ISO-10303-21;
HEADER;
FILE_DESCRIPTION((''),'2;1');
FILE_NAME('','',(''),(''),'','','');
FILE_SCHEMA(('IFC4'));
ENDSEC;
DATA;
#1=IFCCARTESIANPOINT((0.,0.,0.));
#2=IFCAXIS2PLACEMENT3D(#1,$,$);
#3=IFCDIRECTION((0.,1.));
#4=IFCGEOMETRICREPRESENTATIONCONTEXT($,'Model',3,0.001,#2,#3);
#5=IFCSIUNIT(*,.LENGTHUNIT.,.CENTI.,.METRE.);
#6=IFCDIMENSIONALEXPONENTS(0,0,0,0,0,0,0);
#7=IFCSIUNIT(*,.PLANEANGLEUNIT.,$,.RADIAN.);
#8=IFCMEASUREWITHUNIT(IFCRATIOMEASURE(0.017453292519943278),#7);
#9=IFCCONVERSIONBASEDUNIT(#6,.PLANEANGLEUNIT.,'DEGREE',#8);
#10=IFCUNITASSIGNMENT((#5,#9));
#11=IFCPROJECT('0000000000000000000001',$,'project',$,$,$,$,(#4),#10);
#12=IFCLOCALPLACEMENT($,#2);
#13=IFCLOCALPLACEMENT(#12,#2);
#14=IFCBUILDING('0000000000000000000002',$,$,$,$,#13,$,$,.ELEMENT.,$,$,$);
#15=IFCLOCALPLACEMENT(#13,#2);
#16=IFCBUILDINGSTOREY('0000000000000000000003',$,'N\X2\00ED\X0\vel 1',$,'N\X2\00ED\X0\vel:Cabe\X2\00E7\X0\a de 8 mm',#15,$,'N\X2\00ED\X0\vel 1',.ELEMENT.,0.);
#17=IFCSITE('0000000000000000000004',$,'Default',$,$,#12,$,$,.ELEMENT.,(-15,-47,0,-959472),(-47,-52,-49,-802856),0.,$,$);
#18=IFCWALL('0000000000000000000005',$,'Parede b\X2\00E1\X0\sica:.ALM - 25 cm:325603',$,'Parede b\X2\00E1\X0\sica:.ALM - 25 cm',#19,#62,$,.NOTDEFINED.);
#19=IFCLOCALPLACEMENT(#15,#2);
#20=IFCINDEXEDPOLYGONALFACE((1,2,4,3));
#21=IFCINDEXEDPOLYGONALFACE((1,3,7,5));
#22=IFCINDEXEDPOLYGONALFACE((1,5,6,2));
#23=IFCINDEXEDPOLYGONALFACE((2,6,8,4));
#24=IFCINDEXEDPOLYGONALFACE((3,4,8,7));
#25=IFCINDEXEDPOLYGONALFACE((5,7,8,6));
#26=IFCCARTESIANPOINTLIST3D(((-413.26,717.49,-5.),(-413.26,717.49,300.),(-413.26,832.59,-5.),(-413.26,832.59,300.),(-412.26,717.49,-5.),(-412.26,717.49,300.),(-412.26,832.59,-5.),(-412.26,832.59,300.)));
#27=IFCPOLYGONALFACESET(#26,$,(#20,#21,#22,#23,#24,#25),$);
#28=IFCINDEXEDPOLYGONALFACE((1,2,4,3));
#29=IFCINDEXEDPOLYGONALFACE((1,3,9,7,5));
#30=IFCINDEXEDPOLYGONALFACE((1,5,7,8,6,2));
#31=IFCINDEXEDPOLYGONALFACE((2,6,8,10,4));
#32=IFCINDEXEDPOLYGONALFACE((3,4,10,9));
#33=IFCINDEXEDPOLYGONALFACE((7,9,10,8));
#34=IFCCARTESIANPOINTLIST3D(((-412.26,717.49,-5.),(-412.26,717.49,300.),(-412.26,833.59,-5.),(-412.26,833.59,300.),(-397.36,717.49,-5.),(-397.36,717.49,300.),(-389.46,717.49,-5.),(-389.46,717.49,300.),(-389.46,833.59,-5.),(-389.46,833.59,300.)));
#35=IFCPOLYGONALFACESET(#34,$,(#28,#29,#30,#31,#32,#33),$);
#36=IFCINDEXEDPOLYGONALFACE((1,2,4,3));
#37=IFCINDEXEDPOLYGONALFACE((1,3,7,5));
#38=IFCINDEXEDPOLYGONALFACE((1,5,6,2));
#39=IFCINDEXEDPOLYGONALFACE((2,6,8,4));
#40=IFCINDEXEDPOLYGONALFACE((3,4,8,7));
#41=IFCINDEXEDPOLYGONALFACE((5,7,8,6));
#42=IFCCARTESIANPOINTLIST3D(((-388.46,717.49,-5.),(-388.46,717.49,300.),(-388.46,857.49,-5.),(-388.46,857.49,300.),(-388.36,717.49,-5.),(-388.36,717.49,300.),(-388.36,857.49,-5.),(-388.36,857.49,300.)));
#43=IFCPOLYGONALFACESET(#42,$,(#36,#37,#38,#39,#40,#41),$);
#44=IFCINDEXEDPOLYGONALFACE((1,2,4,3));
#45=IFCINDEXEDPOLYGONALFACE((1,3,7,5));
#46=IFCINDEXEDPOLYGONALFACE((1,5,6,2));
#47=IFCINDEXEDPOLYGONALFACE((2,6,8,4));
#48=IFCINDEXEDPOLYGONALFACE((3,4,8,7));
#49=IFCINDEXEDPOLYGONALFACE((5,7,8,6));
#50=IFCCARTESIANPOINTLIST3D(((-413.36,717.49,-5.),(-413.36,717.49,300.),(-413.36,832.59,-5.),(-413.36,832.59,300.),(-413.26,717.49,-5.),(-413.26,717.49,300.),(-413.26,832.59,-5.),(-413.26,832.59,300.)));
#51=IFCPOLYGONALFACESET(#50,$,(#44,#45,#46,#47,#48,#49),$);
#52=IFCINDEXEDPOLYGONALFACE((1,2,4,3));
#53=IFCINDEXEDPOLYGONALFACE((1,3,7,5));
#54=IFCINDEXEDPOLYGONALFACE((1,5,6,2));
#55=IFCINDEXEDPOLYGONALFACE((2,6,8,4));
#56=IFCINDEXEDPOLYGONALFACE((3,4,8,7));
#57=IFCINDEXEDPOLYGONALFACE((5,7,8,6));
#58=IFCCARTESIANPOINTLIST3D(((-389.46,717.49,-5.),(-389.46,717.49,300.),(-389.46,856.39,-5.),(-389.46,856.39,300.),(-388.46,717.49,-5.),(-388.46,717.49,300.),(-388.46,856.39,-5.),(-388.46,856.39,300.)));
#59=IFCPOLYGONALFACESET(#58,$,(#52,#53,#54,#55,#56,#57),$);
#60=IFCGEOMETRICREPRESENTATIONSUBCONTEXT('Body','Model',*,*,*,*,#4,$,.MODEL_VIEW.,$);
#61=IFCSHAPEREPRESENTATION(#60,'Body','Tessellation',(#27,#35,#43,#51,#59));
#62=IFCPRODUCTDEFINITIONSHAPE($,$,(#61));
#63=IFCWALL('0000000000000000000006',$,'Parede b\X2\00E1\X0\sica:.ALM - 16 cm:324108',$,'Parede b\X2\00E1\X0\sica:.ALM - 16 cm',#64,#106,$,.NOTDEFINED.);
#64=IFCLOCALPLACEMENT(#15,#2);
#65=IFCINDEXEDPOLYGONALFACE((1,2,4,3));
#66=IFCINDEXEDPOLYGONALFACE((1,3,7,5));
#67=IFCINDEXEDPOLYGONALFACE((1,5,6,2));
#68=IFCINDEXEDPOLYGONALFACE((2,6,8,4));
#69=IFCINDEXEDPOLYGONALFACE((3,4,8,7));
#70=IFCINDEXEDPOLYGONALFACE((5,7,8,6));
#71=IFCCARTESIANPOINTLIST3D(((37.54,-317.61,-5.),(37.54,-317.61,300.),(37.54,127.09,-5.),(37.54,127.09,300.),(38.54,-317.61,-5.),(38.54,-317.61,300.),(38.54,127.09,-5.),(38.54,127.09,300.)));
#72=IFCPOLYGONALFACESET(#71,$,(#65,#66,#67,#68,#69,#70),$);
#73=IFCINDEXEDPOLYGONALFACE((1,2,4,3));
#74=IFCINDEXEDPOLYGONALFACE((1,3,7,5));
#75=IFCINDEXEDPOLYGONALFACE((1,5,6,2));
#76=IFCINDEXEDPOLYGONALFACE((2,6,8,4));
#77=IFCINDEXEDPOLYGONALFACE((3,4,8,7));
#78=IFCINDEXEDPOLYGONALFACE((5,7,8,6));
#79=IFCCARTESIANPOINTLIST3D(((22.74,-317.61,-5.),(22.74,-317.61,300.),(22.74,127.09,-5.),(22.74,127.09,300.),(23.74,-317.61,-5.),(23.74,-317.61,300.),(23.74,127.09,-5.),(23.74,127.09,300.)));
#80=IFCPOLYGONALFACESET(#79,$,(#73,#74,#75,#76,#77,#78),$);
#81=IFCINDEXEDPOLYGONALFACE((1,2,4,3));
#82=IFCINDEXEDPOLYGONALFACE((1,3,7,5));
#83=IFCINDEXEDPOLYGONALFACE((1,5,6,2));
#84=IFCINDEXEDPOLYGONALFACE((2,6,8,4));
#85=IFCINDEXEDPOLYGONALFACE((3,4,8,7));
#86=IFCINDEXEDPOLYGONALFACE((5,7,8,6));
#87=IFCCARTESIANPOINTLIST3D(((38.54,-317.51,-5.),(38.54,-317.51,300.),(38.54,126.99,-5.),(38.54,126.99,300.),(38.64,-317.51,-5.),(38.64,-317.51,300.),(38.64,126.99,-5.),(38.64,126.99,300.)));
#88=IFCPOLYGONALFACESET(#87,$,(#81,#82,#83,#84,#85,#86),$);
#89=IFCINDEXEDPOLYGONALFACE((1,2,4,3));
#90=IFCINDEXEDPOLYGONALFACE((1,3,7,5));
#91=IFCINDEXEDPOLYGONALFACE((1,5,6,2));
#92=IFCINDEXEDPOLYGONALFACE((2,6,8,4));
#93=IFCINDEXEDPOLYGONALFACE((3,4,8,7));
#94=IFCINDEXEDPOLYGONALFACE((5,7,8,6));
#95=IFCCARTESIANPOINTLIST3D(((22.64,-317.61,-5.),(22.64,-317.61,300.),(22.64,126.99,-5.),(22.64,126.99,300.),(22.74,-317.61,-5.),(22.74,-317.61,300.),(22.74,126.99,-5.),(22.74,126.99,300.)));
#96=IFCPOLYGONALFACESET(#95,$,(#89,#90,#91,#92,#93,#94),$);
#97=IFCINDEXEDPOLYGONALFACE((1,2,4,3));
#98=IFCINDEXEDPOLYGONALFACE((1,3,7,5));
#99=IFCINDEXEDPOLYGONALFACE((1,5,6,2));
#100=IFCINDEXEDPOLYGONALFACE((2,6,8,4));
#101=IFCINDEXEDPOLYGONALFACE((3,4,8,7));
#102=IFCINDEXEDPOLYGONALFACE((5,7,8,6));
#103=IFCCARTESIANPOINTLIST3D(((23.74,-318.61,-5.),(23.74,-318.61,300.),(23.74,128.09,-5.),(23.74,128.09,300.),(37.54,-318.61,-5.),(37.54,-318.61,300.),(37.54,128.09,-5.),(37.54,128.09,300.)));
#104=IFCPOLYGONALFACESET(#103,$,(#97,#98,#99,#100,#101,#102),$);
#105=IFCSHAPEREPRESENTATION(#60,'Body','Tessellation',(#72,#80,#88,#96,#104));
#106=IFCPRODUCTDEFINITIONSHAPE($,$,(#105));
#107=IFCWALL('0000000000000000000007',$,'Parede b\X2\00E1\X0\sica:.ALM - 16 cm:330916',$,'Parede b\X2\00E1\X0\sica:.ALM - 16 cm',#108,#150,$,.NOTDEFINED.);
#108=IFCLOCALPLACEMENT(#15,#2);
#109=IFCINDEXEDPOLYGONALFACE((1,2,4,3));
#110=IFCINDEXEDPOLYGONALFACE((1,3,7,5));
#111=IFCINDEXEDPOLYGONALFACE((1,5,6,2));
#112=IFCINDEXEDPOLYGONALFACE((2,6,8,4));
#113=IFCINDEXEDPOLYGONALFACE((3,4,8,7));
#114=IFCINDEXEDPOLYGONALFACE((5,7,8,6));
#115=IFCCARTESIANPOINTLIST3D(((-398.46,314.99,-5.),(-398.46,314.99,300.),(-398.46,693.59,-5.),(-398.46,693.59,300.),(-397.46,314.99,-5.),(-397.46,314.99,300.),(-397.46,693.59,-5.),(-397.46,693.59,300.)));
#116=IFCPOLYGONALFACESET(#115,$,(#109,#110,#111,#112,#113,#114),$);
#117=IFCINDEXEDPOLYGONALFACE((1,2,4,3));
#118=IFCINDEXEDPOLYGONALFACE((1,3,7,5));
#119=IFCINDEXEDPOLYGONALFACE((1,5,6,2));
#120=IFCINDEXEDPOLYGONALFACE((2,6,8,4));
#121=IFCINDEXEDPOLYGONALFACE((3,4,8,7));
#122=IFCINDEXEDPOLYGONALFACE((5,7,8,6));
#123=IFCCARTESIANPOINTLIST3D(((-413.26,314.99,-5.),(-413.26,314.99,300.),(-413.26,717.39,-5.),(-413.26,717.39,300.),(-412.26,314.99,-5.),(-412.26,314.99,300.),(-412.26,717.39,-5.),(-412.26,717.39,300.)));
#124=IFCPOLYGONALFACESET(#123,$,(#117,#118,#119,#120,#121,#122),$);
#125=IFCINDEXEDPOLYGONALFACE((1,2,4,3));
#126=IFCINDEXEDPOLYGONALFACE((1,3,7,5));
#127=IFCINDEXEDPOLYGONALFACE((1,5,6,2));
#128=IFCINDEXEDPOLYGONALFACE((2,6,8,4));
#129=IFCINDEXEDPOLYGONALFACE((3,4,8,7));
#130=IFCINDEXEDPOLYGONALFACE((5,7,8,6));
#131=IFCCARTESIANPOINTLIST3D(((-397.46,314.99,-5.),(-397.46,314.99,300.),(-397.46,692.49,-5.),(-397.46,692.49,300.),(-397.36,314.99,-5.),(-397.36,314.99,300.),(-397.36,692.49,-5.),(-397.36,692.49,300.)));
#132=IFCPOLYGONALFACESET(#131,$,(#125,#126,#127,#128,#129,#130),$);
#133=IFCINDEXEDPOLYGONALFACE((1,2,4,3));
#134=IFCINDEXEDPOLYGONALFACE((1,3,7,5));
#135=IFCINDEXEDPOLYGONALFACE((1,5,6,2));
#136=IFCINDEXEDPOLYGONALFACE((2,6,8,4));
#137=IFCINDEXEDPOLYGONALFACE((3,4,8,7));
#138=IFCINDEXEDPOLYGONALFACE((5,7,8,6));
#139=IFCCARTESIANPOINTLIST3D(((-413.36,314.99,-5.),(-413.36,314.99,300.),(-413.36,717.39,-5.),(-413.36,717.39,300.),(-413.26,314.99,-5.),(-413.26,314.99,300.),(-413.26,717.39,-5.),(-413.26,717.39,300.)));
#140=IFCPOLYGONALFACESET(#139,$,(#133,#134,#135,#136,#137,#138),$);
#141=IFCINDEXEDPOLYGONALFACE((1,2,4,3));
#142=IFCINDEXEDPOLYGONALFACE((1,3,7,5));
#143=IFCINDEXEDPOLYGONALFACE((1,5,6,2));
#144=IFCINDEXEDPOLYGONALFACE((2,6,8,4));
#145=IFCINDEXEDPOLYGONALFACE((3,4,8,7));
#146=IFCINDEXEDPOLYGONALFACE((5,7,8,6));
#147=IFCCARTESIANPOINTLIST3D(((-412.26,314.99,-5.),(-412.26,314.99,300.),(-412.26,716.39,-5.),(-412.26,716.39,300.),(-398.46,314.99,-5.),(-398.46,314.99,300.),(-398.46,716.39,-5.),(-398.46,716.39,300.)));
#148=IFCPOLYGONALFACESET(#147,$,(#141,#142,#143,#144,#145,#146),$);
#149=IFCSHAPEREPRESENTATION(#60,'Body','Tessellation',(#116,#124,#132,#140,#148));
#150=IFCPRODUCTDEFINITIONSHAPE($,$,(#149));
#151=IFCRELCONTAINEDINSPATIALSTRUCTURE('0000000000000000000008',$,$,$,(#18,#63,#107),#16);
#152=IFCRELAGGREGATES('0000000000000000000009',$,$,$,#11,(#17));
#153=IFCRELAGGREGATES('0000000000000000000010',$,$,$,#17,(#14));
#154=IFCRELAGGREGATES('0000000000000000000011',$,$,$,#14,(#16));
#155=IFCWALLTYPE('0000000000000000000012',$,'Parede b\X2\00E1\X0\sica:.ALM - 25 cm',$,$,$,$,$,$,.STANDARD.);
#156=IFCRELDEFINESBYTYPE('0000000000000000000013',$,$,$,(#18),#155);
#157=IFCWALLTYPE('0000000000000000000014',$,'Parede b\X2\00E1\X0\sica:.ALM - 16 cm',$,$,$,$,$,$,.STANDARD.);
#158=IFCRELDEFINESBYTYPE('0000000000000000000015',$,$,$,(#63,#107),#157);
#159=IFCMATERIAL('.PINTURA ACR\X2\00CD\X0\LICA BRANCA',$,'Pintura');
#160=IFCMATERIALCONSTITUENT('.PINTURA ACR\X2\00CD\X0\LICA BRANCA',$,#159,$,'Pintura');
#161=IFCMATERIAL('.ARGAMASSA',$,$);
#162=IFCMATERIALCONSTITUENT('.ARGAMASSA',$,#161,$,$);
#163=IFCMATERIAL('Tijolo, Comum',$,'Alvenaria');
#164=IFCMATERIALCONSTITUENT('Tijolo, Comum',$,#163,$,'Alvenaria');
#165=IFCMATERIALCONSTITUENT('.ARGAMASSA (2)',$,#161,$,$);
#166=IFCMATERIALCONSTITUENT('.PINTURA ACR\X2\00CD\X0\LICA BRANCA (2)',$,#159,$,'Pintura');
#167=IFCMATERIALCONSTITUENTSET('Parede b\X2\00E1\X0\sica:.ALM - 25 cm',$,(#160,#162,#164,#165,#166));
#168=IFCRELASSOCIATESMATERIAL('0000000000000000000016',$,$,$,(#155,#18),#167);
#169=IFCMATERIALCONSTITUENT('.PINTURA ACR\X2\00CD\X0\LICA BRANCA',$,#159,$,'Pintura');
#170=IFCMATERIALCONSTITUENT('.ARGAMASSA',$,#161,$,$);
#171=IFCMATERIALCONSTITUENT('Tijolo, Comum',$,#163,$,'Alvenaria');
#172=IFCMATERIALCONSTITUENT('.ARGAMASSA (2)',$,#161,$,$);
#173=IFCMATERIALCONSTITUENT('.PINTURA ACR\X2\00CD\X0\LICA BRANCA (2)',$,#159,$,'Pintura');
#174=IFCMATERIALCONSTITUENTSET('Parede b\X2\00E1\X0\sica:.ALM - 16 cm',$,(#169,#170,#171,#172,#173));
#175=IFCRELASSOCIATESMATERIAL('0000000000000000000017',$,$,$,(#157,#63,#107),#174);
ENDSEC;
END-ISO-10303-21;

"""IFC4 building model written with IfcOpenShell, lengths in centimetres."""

from ifc_helpers import new_model, entity, si_unit, converted_unit, direction, frame, origin, place, context, subcontext, project, spatial, indexed_curve, outline, extrude, material, constituent, constituent_set, type_object, element, save


model = new_model("IFC4")

# Units and contexts
model_context = context("Model", 3, precision=0.001, world=origin(), true_north=direction((0.0, 1.0)))
body_context = subcontext(model_context, "Body", "Model", "MODEL_VIEW")
ifc_project = project(units=[si_unit("LENGTHUNIT", "METRE", prefix="CENTI"), converted_unit("PLANEANGLEUNIT", "DEGREE", entity("IfcRatioMeasure", 0.017453292519943278), si_unit("PLANEANGLEUNIT", "RADIAN"), dimensions=[0, 0, 0, 0, 0, 0, 0])], contexts=[model_context])

# Site, building, storey
site_placement = place(None, origin())
site = spatial("IfcSite", under=ifc_project, at=site_placement, Name="Default", CompositionType="ELEMENT", RefLatitude=(-15, -47, 0, -959472), RefLongitude=(-47, -52, -49, -802856), RefElevation=0.0)
building_placement = place(site_placement, origin())
building = spatial("IfcBuilding", under=site, at=building_placement, CompositionType="ELEMENT")
storey_placement = place(building_placement, origin())
storey = spatial("IfcBuildingStorey", under=building, at=storey_placement, Name="Nível 1", ObjectType="Nível:Cabeça de 8 mm", LongName="Nível 1", CompositionType="ELEMENT", Elevation=0.0)

# Shared definitions
ifc_material_1 = material(Name=".PINTURA ACRÍLICA BRANCA", Category="Pintura")
ifc_constituent_1 = constituent(ifc_material_1, Name=".PINTURA ACRÍLICA BRANCA", Category="Pintura")
ifc_material_2 = material(Name=".ARGAMASSA")
ifc_constituent_2 = constituent(ifc_material_2, Name=".ARGAMASSA")
ifc_material_3 = material(Name="Tijolo, Comum", Category="Alvenaria")
ifc_constituent_3 = constituent(ifc_material_3, Name="Tijolo, Comum", Category="Alvenaria")
ifc_constituent_4 = constituent(ifc_material_2, Name=".ARGAMASSA (2)")
ifc_constituent_5 = constituent(ifc_material_1, Name=".PINTURA ACRÍLICA BRANCA (2)", Category="Pintura")
ifc_constituent_set_1 = constituent_set(constituents=[ifc_constituent_1, ifc_constituent_2, ifc_constituent_3, ifc_constituent_4, ifc_constituent_5], Name="Parede básica:.ALM - 25 cm")
wall_type_1 = type_object("IfcWallType", Name="Parede básica:.ALM - 25 cm", PredefinedType="STANDARD", material=ifc_constituent_set_1)

# Wall
wall_1_placement = place(storey_placement, frame((-400.86, 717.49, -5.0), z_axis=(0.0, 0.0, 1.0), x_axis=(0.0, 1.0, 0.0)))
element("IfcWall", 1, at=wall_1_placement, inside=storey, type_object=wall_type_1, material=ifc_constituent_set_1, Name="Parede básica:.ALM - 25 cm:325603", ObjectType="Parede básica:.ALM - 25 cm", PredefinedType="NOTDEFINED", context=body_context, shape_type="SweptSolid", body=[
    extrude(outline(indexed_curve([(-0.5, -57.55), (0.5, -57.55), (0.5, 57.55), (-0.5, 57.55), (-0.5, -57.55)], self_intersect=False)), frame((57.55, 11.9, 0.0), z_axis=(0.0, 0.0, 1.0), x_axis=(0.0, -1.0, 0.0)), (0.0, 0.0, 1.0), 305.0),
    extrude(outline(indexed_curve([(-10.7, -69.66), (12.1, -69.66), (12.1, 46.44), (-2.8, 46.44), (-10.7, 46.44), (-10.7, -69.66)], self_intersect=False)), frame((46.44, -0.7, 0.0), z_axis=(0.0, 0.0, 1.0), x_axis=(0.0, 1.0, 0.0)), (0.0, 0.0, 1.0), 305.0),
    extrude(outline(indexed_curve([(-0.05, -70.0), (0.05, -70.0), (0.05, 70.0), (-0.05, 70.0), (-0.05, -70.0)], self_intersect=False)), frame((70.0, -12.45, 0.0), z_axis=(0.0, 0.0, 1.0), x_axis=(0.0, -1.0, 0.0)), (0.0, 0.0, 1.0), 305.0),
    extrude(outline(indexed_curve([(-0.05, -57.55), (0.05, -57.55), (0.05, 57.55), (-0.05, 57.55), (-0.05, -57.55)], self_intersect=False)), frame((57.55, 12.45, 0.0), z_axis=(0.0, 0.0, 1.0), x_axis=(0.0, 1.0, 0.0)), (0.0, 0.0, 1.0), 305.0),
    extrude(outline(indexed_curve([(-0.5, -69.45), (0.5, -69.45), (0.5, 69.45), (-0.5, 69.45), (-0.5, -69.45)], self_intersect=False)), frame((69.45, -11.9, 0.0), z_axis=(0.0, 0.0, 1.0), x_axis=(0.0, -1.0, 0.0)), (0.0, 0.0, 1.0), 305.0),
])

# Walls
ifc_constituent_6 = constituent(ifc_material_1, Name=".PINTURA ACRÍLICA BRANCA", Category="Pintura")
ifc_constituent_7 = constituent(ifc_material_2, Name=".ARGAMASSA")
ifc_constituent_8 = constituent(ifc_material_3, Name="Tijolo, Comum", Category="Alvenaria")
ifc_constituent_9 = constituent(ifc_material_2, Name=".ARGAMASSA (2)")
ifc_constituent_10 = constituent(ifc_material_1, Name=".PINTURA ACRÍLICA BRANCA (2)", Category="Pintura")
ifc_constituent_set_2 = constituent_set(constituents=[ifc_constituent_6, ifc_constituent_7, ifc_constituent_8, ifc_constituent_9, ifc_constituent_10], Name="Parede básica:.ALM - 16 cm")
wall_type_2 = type_object("IfcWallType", Name="Parede básica:.ALM - 16 cm", PredefinedType="STANDARD", material=ifc_constituent_set_2)
wall_2_placement = place(storey_placement, frame((30.64, -317.51, -5.0), z_axis=(0.0, 0.0, 1.0), x_axis=(0.0, 1.0, 0.0)))
element("IfcWall", 2, at=wall_2_placement, inside=storey, type_object=wall_type_2, material=ifc_constituent_set_2, Name="Parede básica:.ALM - 16 cm:324108", ObjectType="Parede básica:.ALM - 16 cm", PredefinedType="NOTDEFINED", context=body_context, shape_type="SweptSolid", body=[
    extrude(outline(indexed_curve([(-222.35, -0.5), (222.35, -0.5), (222.35, 0.5), (-222.35, 0.5), (-222.35, -0.5)], self_intersect=False)), frame((222.25, -7.4, 0.0)), (0.0, 0.0, 1.0), 305.0),
    extrude(outline(indexed_curve([(-222.35, -0.5), (222.35, -0.5), (222.35, 0.5), (-222.35, 0.5), (-222.35, -0.5)], self_intersect=False)), frame((222.25, 7.4, 0.0)), (0.0, 0.0, 1.0), 305.0),
    extrude(outline(indexed_curve([(-0.05, -222.25), (0.05, -222.25), (0.05, 222.25), (-0.05, 222.25), (-0.05, -222.25)], self_intersect=False)), frame((222.25, -7.95, 0.0), z_axis=(0.0, 0.0, 1.0), x_axis=(0.0, 1.0, 0.0)), (0.0, 0.0, 1.0), 305.0),
    extrude(outline(indexed_curve([(-0.05, -222.3), (0.05, -222.3), (0.05, 222.3), (-0.05, 222.3), (-0.05, -222.3)], self_intersect=False)), frame((222.2, 7.95, 0.0), z_axis=(0.0, 0.0, 1.0), x_axis=(0.0, -1.0, 0.0)), (0.0, 0.0, 1.0), 305.0),
    extrude(outline(indexed_curve([(-223.35, -6.9), (223.35, -6.9), (223.35, 6.9), (-223.35, 6.9), (-223.35, -6.9)], self_intersect=False)), frame((222.25, 0.0, 0.0)), (0.0, 0.0, 1.0), 305.0),
])
wall_3_placement = place(storey_placement, frame((-405.36, 314.99, -5.0), z_axis=(0.0, 0.0, 1.0), x_axis=(0.0, 1.0, 0.0)))
element("IfcWall", 3, at=wall_3_placement, inside=storey, type_object=wall_type_2, material=ifc_constituent_set_2, Name="Parede básica:.ALM - 16 cm:330916", ObjectType="Parede básica:.ALM - 16 cm", PredefinedType="NOTDEFINED", context=body_context, shape_type="SweptSolid", body=[
    extrude(outline(indexed_curve([(-189.3, -0.5), (189.3, -0.5), (189.3, 0.5), (-189.3, 0.5), (-189.3, -0.5)], self_intersect=False)), frame((189.3, -7.4, 0.0)), (0.0, 0.0, 1.0), 305.0),
    extrude(outline(indexed_curve([(-201.2, -0.5), (201.2, -0.5), (201.2, 0.5), (-201.2, 0.5), (-201.2, -0.5)], self_intersect=False)), frame((201.2, 7.4, 0.0)), (0.0, 0.0, 1.0), 305.0),
    extrude(outline(indexed_curve([(-0.05, -188.75), (0.05, -188.75), (0.05, 188.75), (-0.05, 188.75), (-0.05, -188.75)], self_intersect=False)), frame((188.75, -7.95, 0.0), z_axis=(0.0, 0.0, 1.0), x_axis=(0.0, 1.0, 0.0)), (0.0, 0.0, 1.0), 305.0),
    extrude(outline(indexed_curve([(-0.05, -201.2), (0.05, -201.2), (0.05, 201.2), (-0.05, 201.2), (-0.05, -201.2)], self_intersect=False)), frame((201.2, 7.95, 0.0), z_axis=(0.0, 0.0, 1.0), x_axis=(0.0, -1.0, 0.0)), (0.0, 0.0, 1.0), 305.0),
    extrude(outline(indexed_curve([(-200.7, -6.9), (200.7, -6.9), (200.7, 6.9), (-200.7, 6.9), (-200.7, -6.9)], self_intersect=False)), frame((200.7, 0.0, 0.0)), (0.0, 0.0, 1.0), 305.0),
])

save(model, "model.ifc")
